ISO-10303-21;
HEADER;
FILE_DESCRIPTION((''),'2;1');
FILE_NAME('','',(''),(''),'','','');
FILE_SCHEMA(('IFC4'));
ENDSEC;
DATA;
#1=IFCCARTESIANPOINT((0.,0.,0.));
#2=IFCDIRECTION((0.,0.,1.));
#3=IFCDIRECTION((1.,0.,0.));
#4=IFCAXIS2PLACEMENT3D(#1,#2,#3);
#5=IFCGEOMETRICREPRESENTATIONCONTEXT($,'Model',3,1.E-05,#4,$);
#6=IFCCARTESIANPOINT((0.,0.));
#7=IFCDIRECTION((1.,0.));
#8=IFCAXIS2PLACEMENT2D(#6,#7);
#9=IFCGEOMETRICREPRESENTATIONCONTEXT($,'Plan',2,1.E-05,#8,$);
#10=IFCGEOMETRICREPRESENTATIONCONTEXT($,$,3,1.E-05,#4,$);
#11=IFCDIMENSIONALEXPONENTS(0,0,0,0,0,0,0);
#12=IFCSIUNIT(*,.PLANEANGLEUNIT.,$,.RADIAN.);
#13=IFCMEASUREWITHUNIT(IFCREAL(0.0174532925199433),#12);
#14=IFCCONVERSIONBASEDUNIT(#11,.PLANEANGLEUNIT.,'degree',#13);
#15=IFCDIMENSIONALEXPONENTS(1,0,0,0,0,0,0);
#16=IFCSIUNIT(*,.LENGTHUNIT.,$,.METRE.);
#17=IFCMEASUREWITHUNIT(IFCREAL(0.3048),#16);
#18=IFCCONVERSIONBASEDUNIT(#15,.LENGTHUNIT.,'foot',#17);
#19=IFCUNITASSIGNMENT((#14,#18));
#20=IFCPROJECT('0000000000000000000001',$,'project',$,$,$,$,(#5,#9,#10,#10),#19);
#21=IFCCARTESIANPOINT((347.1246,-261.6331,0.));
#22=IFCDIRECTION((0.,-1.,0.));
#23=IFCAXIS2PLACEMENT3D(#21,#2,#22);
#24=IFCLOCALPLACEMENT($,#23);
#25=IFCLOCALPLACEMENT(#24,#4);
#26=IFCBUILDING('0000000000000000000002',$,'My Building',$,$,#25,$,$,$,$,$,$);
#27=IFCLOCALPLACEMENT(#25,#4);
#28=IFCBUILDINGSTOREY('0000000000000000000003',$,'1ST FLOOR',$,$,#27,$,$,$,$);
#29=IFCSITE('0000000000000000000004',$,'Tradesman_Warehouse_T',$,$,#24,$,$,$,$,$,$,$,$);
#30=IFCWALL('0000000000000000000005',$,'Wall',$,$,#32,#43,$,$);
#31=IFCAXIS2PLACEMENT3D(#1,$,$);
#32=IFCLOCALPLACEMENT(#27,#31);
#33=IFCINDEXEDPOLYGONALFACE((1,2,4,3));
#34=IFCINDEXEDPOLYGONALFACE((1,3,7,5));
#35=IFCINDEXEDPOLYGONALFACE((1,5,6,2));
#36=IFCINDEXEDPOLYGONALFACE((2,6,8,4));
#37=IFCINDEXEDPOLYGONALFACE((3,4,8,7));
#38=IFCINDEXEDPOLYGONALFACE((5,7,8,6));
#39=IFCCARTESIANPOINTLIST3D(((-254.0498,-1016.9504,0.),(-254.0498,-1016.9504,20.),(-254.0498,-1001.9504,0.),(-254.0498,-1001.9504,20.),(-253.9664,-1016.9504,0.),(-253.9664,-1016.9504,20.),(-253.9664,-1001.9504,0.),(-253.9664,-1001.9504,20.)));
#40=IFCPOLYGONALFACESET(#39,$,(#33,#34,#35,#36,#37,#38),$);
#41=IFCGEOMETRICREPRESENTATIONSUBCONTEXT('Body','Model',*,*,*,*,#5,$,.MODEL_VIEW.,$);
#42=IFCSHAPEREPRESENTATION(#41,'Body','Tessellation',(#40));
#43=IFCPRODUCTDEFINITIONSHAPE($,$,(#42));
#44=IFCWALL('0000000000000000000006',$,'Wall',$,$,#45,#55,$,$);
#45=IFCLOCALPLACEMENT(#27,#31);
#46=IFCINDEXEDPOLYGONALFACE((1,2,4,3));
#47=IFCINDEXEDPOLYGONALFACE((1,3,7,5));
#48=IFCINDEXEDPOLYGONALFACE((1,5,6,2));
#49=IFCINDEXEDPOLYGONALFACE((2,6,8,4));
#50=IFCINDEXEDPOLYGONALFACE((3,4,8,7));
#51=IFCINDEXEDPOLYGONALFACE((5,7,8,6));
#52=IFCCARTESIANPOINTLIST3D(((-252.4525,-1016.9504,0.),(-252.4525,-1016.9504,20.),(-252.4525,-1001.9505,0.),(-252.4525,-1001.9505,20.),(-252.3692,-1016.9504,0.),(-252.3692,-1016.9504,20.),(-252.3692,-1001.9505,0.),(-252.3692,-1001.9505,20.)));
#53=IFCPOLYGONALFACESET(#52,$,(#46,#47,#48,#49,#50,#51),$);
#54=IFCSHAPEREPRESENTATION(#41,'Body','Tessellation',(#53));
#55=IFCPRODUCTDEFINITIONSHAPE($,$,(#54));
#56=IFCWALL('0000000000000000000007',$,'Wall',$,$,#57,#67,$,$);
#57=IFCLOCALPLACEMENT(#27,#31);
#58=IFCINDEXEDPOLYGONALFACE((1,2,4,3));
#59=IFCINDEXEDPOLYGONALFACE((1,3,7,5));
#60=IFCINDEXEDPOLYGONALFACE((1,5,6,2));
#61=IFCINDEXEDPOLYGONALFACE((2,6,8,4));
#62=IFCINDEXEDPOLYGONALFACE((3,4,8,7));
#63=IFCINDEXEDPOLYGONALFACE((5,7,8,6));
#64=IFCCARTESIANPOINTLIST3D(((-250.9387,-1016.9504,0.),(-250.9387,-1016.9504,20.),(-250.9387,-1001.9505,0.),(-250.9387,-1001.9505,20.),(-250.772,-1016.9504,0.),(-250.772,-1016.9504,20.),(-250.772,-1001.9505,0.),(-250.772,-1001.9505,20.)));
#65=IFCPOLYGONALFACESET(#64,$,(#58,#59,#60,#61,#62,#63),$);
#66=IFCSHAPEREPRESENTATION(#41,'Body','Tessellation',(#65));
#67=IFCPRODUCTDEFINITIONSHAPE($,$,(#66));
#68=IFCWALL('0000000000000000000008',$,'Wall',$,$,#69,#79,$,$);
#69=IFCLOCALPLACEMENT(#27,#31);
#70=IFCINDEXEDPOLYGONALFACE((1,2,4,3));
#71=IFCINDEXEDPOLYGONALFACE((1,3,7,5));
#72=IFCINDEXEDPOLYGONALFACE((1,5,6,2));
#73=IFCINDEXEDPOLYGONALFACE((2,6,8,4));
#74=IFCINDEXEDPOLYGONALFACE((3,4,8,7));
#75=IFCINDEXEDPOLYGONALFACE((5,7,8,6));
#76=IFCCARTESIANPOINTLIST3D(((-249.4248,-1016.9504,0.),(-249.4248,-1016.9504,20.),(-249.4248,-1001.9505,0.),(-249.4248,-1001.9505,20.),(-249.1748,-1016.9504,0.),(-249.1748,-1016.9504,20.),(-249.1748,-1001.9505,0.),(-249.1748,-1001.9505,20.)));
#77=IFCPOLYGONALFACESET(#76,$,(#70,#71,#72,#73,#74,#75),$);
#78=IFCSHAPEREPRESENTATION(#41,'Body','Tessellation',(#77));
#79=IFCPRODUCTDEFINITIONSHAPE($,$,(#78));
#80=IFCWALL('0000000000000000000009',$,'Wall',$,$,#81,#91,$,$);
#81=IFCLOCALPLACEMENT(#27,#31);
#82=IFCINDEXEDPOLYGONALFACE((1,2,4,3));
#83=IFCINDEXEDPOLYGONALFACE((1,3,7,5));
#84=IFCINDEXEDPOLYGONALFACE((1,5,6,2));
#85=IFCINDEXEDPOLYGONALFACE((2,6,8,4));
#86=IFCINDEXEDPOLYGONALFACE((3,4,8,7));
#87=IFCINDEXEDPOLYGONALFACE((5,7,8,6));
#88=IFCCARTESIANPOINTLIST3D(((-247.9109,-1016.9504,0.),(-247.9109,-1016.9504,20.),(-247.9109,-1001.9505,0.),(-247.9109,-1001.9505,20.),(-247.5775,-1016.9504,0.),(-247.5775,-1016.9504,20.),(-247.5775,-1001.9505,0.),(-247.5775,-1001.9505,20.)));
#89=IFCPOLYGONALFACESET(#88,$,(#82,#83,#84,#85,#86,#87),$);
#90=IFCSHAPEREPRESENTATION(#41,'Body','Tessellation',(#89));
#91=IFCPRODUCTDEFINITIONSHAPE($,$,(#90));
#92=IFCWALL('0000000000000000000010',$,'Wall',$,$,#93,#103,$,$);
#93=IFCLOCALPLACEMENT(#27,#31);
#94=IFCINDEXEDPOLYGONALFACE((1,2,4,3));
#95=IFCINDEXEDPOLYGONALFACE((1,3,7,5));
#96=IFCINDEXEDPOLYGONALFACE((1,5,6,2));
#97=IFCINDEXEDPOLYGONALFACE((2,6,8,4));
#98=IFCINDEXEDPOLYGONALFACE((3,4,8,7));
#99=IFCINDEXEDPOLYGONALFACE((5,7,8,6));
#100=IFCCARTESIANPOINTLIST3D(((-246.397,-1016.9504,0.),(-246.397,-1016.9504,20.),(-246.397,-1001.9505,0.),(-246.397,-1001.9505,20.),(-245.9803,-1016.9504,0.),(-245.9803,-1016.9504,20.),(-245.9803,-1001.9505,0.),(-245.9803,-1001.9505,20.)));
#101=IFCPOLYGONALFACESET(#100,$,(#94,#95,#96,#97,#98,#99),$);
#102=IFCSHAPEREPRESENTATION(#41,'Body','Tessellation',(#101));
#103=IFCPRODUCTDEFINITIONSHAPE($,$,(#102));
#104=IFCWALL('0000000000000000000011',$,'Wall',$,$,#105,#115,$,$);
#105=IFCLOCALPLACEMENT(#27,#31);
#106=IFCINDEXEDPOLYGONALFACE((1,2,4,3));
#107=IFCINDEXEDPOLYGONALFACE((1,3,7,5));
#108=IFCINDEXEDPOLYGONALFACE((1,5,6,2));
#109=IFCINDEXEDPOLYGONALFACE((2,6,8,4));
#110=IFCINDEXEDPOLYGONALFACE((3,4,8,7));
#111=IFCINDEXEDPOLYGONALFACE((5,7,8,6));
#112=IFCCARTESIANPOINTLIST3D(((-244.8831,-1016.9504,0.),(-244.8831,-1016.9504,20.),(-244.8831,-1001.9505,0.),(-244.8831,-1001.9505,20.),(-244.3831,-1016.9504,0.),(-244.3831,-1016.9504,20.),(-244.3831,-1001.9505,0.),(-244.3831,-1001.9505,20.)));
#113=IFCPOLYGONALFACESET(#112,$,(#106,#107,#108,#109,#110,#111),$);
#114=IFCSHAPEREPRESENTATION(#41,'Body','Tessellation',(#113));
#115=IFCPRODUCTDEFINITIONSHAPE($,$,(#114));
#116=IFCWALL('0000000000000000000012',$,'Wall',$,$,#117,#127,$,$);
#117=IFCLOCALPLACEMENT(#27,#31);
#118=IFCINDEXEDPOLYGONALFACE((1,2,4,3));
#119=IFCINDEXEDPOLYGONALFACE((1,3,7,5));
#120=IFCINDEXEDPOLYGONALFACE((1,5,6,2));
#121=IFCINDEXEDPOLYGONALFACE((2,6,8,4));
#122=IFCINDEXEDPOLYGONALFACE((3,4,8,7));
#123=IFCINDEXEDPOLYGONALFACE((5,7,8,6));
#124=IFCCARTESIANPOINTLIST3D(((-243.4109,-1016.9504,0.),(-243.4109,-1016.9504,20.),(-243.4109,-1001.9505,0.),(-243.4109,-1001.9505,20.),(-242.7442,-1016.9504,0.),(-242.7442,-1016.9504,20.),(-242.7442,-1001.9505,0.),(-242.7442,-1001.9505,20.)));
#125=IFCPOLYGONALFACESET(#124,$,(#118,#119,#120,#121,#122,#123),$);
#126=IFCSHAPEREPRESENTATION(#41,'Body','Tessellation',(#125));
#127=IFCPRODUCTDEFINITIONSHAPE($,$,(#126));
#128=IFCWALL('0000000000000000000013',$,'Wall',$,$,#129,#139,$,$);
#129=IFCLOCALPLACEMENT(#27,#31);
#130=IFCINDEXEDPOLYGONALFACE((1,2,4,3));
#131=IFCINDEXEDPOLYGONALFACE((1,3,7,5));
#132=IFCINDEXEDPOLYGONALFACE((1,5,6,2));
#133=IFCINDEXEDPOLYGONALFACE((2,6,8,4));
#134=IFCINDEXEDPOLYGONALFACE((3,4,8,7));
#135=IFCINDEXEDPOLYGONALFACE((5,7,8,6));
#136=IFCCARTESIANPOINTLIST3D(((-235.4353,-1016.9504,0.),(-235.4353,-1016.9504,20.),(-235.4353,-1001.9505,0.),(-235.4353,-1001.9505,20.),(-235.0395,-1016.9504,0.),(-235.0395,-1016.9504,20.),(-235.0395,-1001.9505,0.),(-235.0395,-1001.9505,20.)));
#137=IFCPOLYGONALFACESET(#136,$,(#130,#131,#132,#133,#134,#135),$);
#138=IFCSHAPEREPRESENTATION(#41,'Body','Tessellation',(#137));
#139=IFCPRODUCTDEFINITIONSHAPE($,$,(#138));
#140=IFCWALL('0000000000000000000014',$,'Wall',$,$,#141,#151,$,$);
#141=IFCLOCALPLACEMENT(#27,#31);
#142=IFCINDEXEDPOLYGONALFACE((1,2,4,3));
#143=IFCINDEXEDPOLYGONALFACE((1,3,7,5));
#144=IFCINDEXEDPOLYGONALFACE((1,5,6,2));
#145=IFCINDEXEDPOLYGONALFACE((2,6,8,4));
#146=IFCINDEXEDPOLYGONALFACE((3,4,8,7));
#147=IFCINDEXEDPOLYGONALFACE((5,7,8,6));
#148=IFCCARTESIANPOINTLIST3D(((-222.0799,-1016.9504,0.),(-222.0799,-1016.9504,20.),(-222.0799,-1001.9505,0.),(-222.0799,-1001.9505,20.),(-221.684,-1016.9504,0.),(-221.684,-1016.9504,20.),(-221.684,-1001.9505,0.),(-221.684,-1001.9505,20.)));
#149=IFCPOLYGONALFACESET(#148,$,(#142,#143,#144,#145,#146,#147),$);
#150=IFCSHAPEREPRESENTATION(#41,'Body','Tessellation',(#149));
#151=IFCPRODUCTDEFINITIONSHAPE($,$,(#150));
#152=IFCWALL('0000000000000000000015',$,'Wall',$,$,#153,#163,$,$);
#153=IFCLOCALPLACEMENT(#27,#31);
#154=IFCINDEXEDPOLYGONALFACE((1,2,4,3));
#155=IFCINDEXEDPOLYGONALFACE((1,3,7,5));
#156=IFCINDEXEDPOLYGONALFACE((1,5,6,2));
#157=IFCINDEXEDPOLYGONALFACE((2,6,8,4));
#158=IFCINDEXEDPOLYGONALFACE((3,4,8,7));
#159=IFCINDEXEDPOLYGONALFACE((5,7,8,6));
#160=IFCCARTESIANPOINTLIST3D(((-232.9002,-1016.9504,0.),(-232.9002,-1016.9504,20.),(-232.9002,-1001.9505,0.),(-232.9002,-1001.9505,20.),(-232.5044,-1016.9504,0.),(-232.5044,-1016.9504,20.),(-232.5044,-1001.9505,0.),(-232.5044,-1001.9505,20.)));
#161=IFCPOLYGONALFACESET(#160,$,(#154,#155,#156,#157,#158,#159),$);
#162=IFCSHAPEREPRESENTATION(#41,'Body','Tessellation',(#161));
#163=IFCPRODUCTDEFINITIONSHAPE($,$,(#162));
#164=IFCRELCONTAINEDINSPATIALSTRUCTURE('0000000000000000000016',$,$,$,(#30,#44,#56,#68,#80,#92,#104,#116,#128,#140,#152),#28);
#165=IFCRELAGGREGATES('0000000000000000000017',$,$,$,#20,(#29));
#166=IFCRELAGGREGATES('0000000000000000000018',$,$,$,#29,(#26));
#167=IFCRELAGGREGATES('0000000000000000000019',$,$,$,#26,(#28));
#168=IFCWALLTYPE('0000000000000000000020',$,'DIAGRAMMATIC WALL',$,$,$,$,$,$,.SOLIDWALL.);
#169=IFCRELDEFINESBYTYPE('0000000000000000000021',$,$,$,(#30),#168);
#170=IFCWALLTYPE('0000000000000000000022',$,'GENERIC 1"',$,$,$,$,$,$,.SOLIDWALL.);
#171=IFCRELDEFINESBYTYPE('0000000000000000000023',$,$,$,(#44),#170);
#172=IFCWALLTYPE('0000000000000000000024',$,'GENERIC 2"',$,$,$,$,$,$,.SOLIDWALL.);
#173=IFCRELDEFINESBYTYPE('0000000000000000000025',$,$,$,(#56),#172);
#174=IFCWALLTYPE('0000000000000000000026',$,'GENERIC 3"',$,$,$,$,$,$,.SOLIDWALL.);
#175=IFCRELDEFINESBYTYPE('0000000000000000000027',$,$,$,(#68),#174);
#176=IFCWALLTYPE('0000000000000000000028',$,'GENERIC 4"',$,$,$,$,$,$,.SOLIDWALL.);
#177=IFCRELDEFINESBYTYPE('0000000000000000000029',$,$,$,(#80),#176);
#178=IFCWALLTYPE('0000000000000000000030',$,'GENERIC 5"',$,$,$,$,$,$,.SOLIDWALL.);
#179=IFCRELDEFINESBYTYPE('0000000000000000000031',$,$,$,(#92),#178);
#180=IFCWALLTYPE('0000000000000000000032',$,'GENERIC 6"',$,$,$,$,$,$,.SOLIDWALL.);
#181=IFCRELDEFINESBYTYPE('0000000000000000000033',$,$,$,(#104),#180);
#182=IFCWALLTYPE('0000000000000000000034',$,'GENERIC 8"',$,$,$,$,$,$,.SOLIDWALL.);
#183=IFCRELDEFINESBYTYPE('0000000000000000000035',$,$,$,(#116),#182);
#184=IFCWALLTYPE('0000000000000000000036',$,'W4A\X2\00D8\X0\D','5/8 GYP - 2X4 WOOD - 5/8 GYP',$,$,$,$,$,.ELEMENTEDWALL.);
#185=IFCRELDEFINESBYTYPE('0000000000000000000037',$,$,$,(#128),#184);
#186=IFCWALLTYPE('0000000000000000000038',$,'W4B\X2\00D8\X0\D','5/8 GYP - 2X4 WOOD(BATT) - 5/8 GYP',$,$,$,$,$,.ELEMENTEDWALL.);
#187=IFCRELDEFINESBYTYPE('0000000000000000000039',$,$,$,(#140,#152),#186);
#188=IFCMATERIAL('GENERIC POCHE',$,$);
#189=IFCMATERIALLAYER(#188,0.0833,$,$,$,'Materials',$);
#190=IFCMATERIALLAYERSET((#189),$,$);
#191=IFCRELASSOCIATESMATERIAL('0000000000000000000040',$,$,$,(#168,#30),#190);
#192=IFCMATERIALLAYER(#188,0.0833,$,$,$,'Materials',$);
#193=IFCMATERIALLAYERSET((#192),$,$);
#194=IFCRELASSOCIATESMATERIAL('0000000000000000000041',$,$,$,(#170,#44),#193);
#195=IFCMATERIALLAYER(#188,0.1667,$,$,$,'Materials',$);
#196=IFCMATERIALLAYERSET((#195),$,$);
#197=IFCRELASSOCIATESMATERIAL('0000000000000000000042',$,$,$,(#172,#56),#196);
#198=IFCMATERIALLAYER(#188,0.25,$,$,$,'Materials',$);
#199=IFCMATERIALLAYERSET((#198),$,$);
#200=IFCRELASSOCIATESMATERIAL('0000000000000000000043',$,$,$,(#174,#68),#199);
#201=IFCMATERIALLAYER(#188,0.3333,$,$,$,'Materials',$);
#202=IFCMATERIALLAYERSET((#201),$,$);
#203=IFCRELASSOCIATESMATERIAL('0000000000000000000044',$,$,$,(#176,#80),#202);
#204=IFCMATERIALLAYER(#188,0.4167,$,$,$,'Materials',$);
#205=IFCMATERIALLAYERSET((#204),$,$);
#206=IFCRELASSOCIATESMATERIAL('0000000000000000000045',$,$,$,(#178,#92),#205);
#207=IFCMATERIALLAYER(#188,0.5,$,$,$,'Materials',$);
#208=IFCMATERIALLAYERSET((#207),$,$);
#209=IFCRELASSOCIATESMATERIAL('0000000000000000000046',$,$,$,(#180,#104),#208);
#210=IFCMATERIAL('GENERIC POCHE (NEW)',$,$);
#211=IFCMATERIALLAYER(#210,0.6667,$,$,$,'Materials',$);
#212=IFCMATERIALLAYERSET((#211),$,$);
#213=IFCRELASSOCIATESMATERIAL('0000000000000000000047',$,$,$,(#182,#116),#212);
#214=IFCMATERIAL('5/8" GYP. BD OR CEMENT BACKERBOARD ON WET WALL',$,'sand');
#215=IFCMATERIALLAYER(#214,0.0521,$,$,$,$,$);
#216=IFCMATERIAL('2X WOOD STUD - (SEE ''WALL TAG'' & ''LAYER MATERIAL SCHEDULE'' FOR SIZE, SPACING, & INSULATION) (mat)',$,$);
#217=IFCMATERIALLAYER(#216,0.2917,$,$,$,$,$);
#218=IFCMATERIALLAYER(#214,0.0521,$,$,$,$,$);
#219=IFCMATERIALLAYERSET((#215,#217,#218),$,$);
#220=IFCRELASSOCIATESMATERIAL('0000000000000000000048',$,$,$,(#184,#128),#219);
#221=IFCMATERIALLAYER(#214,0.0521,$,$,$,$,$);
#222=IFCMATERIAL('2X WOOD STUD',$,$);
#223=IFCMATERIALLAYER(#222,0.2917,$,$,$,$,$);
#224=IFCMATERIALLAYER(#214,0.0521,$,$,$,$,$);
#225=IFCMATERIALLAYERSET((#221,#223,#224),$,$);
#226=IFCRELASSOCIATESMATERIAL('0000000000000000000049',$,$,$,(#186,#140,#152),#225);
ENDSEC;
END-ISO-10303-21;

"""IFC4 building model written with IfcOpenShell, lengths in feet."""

from ifc_helpers import new_model, entity, si_unit, converted_unit, frame, origin_with_axes, origin_2d_with_axis, place, context, subcontext, project, spatial, indexed_curve, outline, extrude, material, layer, layer_set, layer_usage, type_object, element, save


model = new_model("IFC4")

# Units and contexts
model_context = context("Model", 3, precision=1e-05, world=origin_with_axes())
plan_context = context("Plan", 2, precision=1e-05, world=origin_2d_with_axis())
context_of_model = context(None, 3, precision=1e-05, world=origin_with_axes())
body_context = subcontext(model_context, "Body", "Model", "MODEL_VIEW")
ifc_project = project(units=[converted_unit("PLANEANGLEUNIT", "degree", entity("IfcReal", 0.0174532925199433), si_unit("PLANEANGLEUNIT", "RADIAN"), dimensions=[0, 0, 0, 0, 0, 0, 0]), converted_unit("LENGTHUNIT", "foot", entity("IfcReal", 0.3048), si_unit("LENGTHUNIT", "METRE"), dimensions=[1, 0, 0, 0, 0, 0, 0])], contexts=[model_context, plan_context, context_of_model, context_of_model])

# Site, building, storey
site_placement = place(None, frame((347.1246, -261.6331, 0.0), z_axis=(0.0, 0.0, 1.0), x_axis=(0.0, -1.0, 0.0)))
site = spatial("IfcSite", under=ifc_project, at=site_placement, Name="Tradesman_Warehouse_T")
building_placement = place(site_placement, frame((0.0, 0.0, 0.0), z_axis=(0.0, 0.0, 1.0), x_axis=(1.0, 0.0, 0.0)))
building = spatial("IfcBuilding", under=site, at=building_placement, Name="My Building")
storey_placement = place(building_placement, frame((0.0, 0.0, 0.0), z_axis=(0.0, 0.0, 1.0), x_axis=(1.0, 0.0, 0.0)))
storey = spatial("IfcBuildingStorey", under=building, at=storey_placement, Name="1ST FLOOR")

# Walls
ifc_material_1 = material(Name="GENERIC POCHE")
ifc_layer_1 = layer(ifc_material_1, 0.0833, Category="Materials")
ifc_layer_set_1 = layer_set([ifc_layer_1])
ifc_layer_usage_1 = layer_usage(ifc_layer_set_1, "AXIS2", "POSITIVE", 0.0)
wall_type_1 = type_object("IfcWallType", Name="DIAGRAMMATIC WALL", PredefinedType="SOLIDWALL", material=ifc_layer_set_1)
wall_1_placement = place(storey_placement, frame((-253.9664, -1016.9504, 0.0), z_axis=(0.0, 0.0, 1.0), x_axis=(0.0, 1.0, 0.0)))
element("IfcWall", 1, at=wall_1_placement, inside=storey, type_object=wall_type_1, material=ifc_layer_usage_1, Name="Wall", context=body_context, shape_type="SweptSolid", body=[
    extrude(outline(indexed_curve([(0.0, 0.0), (0.0, 0.0833), (15.0, 0.0833), (15.0, 0.0), (0.0, 0.0)], self_intersect=False)), origin_with_axes(), (0.0, 0.0, 1.0), 20.0),
])
ifc_layer_2 = layer(ifc_material_1, 0.0833, Category="Materials")
ifc_layer_set_2 = layer_set([ifc_layer_2])
ifc_layer_usage_2 = layer_usage(ifc_layer_set_2, "AXIS2", "POSITIVE", 0.0)
wall_type_2 = type_object("IfcWallType", Name="GENERIC 1\"", PredefinedType="SOLIDWALL", material=ifc_layer_set_2)
wall_2_placement = place(storey_placement, frame((-252.3692, -1016.9504, 0.0), z_axis=(0.0, 0.0, 1.0), x_axis=(0.0, 1.0, 0.0)))
element("IfcWall", 2, at=wall_2_placement, inside=storey, type_object=wall_type_2, material=ifc_layer_usage_2, Name="Wall", context=body_context, shape_type="SweptSolid", body=[
    extrude(outline(indexed_curve([(0.0, 0.0), (0.0, 0.0833), (15.0, 0.0833), (15.0, 0.0), (0.0, 0.0)], self_intersect=False)), origin_with_axes(), (0.0, 0.0, 1.0), 20.0),
])
ifc_layer_3 = layer(ifc_material_1, 0.1667, Category="Materials")
ifc_layer_set_3 = layer_set([ifc_layer_3])
ifc_layer_usage_3 = layer_usage(ifc_layer_set_3, "AXIS2", "POSITIVE", 0.0)
wall_type_3 = type_object("IfcWallType", Name="GENERIC 2\"", PredefinedType="SOLIDWALL", material=ifc_layer_set_3)
wall_3_placement = place(storey_placement, frame((-250.772, -1016.9504, 0.0), z_axis=(0.0, 0.0, 1.0), x_axis=(0.0, 1.0, 0.0)))
element("IfcWall", 3, at=wall_3_placement, inside=storey, type_object=wall_type_3, material=ifc_layer_usage_3, Name="Wall", context=body_context, shape_type="SweptSolid", body=[
    extrude(outline(indexed_curve([(0.0, 0.0), (0.0, 0.1667), (14.9999, 0.1667), (14.9999, 0.0), (0.0, 0.0)], self_intersect=False)), origin_with_axes(), (0.0, 0.0, 1.0), 20.0),
])
ifc_layer_4 = layer(ifc_material_1, 0.25, Category="Materials")
ifc_layer_set_4 = layer_set([ifc_layer_4])
ifc_layer_usage_4 = layer_usage(ifc_layer_set_4, "AXIS2", "POSITIVE", 0.0)
wall_type_4 = type_object("IfcWallType", Name="GENERIC 3\"", PredefinedType="SOLIDWALL", material=ifc_layer_set_4)
wall_4_placement = place(storey_placement, frame((-249.1748, -1016.9504, 0.0), z_axis=(0.0, 0.0, 1.0), x_axis=(0.0, 1.0, 0.0)))
element("IfcWall", 4, at=wall_4_placement, inside=storey, type_object=wall_type_4, material=ifc_layer_usage_4, Name="Wall", context=body_context, shape_type="SweptSolid", body=[
    extrude(outline(indexed_curve([(0.0, 0.0), (0.0, 0.25), (14.9999, 0.25), (14.9999, 0.0), (0.0, 0.0)], self_intersect=False)), origin_with_axes(), (0.0, 0.0, 1.0), 20.0),
])
ifc_layer_5 = layer(ifc_material_1, 0.3333, Category="Materials")
ifc_layer_set_5 = layer_set([ifc_layer_5])
ifc_layer_usage_5 = layer_usage(ifc_layer_set_5, "AXIS2", "POSITIVE", 0.0)
wall_type_5 = type_object("IfcWallType", Name="GENERIC 4\"", PredefinedType="SOLIDWALL", material=ifc_layer_set_5)
wall_5_placement = place(storey_placement, frame((-247.5775, -1016.9504, 0.0), z_axis=(0.0, 0.0, 1.0), x_axis=(0.0, 1.0, 0.0)))
element("IfcWall", 5, at=wall_5_placement, inside=storey, type_object=wall_type_5, material=ifc_layer_usage_5, Name="Wall", context=body_context, shape_type="SweptSolid", body=[
    extrude(outline(indexed_curve([(0.0, 0.0), (0.0, 0.3333), (14.9999, 0.3333), (14.9999, 0.0), (0.0, 0.0)], self_intersect=False)), origin_with_axes(), (0.0, 0.0, 1.0), 20.0),
])
ifc_layer_6 = layer(ifc_material_1, 0.4167, Category="Materials")
ifc_layer_set_6 = layer_set([ifc_layer_6])
ifc_layer_usage_6 = layer_usage(ifc_layer_set_6, "AXIS2", "POSITIVE", 0.0)
wall_type_6 = type_object("IfcWallType", Name="GENERIC 5\"", PredefinedType="SOLIDWALL", material=ifc_layer_set_6)
wall_6_placement = place(storey_placement, frame((-245.9803, -1016.9504, 0.0), z_axis=(0.0, 0.0, 1.0), x_axis=(0.0, 1.0, 0.0)))
element("IfcWall", 6, at=wall_6_placement, inside=storey, type_object=wall_type_6, material=ifc_layer_usage_6, Name="Wall", context=body_context, shape_type="SweptSolid", body=[
    extrude(outline(indexed_curve([(0.0, 0.0), (0.0, 0.4167), (14.9999, 0.4167), (14.9999, 0.0), (0.0, 0.0)], self_intersect=False)), origin_with_axes(), (0.0, 0.0, 1.0), 20.0),
])
ifc_layer_7 = layer(ifc_material_1, 0.5, Category="Materials")
ifc_layer_set_7 = layer_set([ifc_layer_7])
ifc_layer_usage_7 = layer_usage(ifc_layer_set_7, "AXIS2", "POSITIVE", 0.0)
wall_type_7 = type_object("IfcWallType", Name="GENERIC 6\"", PredefinedType="SOLIDWALL", material=ifc_layer_set_7)
wall_7_placement = place(storey_placement, frame((-244.3831, -1016.9504, 0.0), z_axis=(0.0, 0.0, 1.0), x_axis=(0.0, 1.0, 0.0)))
element("IfcWall", 7, at=wall_7_placement, inside=storey, type_object=wall_type_7, material=ifc_layer_usage_7, Name="Wall", context=body_context, shape_type="SweptSolid", body=[
    extrude(outline(indexed_curve([(0.0, 0.0), (0.0, 0.5), (14.9999, 0.5), (14.9999, 0.0), (0.0, 0.0)], self_intersect=False)), origin_with_axes(), (0.0, 0.0, 1.0), 20.0),
])
ifc_material_2 = material(Name="GENERIC POCHE (NEW)")
ifc_layer_8 = layer(ifc_material_2, 0.6667, Category="Materials")
ifc_layer_set_8 = layer_set([ifc_layer_8])
ifc_layer_usage_8 = layer_usage(ifc_layer_set_8, "AXIS2", "POSITIVE", 0.0)
wall_type_8 = type_object("IfcWallType", Name="GENERIC 8\"", PredefinedType="SOLIDWALL", material=ifc_layer_set_8)
wall_8_placement = place(storey_placement, frame((-242.7442, -1016.9504, 0.0), z_axis=(0.0, 0.0, 1.0), x_axis=(0.0, 1.0, 0.0)))
element("IfcWall", 8, at=wall_8_placement, inside=storey, type_object=wall_type_8, material=ifc_layer_usage_8, Name="Wall", context=body_context, shape_type="SweptSolid", body=[
    extrude(outline(indexed_curve([(0.0, 0.0), (0.0, 0.6667), (14.9999, 0.6667), (14.9999, 0.0), (0.0, 0.0)], self_intersect=False)), origin_with_axes(), (0.0, 0.0, 1.0), 20.0),
])
ifc_material_3 = material(Name="5/8\" GYP. BD OR CEMENT BACKERBOARD ON WET WALL", Category="sand")
ifc_layer_9 = layer(ifc_material_3, 0.0521)
ifc_material_4 = material(Name="2X WOOD STUD - (SEE 'WALL TAG' & 'LAYER MATERIAL SCHEDULE' FOR SIZE, SPACING, & INSULATION) (mat)")
ifc_layer_10 = layer(ifc_material_4, 0.2917)
ifc_layer_11 = layer(ifc_material_3, 0.0521)
ifc_layer_set_9 = layer_set([ifc_layer_9, ifc_layer_10, ifc_layer_11])
ifc_layer_usage_9 = layer_usage(ifc_layer_set_9, "AXIS2", "POSITIVE", 0.0)
wall_type_9 = type_object("IfcWallType", Name="W4AØD", Description="5/8 GYP - 2X4 WOOD - 5/8 GYP", PredefinedType="ELEMENTEDWALL", material=ifc_layer_set_9)
wall_9_placement = place(storey_placement, frame((-235.0395, -1016.9504, 0.0), z_axis=(0.0, 0.0, 1.0), x_axis=(0.0, 1.0, 0.0)))
element("IfcWall", 9, at=wall_9_placement, inside=storey, type_object=wall_type_9, material=ifc_layer_usage_9, Name="Wall", context=body_context, shape_type="SweptSolid", body=[
    extrude(outline(indexed_curve([(0.0, 0.0), (0.0, 0.3958), (14.9999, 0.3958), (14.9999, 0.0), (0.0, 0.0)], self_intersect=False)), origin_with_axes(), (0.0, 0.0, 1.0), 20.0),
])
ifc_layer_12 = layer(ifc_material_3, 0.0521)
ifc_material_5 = material(Name="2X WOOD STUD")
ifc_layer_13 = layer(ifc_material_5, 0.2917)
ifc_layer_14 = layer(ifc_material_3, 0.0521)
ifc_layer_set_10 = layer_set([ifc_layer_12, ifc_layer_13, ifc_layer_14])
ifc_layer_usage_10 = layer_usage(ifc_layer_set_10, "AXIS2", "POSITIVE", 0.0)
wall_type_10 = type_object("IfcWallType", Name="W4BØD", Description="5/8 GYP - 2X4 WOOD(BATT) - 5/8 GYP", PredefinedType="ELEMENTEDWALL", material=ifc_layer_set_10)
wall_10_placement = place(storey_placement, frame((-221.684, -1016.9504, 0.0), z_axis=(0.0, 0.0, 1.0), x_axis=(0.0, 1.0, 0.0)))
element("IfcWall", 10, at=wall_10_placement, inside=storey, type_object=wall_type_10, material=ifc_layer_usage_10, Name="Wall", context=body_context, shape_type="SweptSolid", body=[
    extrude(outline(indexed_curve([(0.0, 0.0), (0.0, 0.3958), (14.9999, 0.3958), (14.9999, 0.0), (0.0, 0.0)], self_intersect=False)), origin_with_axes(), (0.0, 0.0, 1.0), 20.0),
])
ifc_layer_usage_11 = layer_usage(ifc_layer_set_10, "AXIS2", "POSITIVE", 0.0)
wall_11_placement = place(storey_placement, frame((-232.5044, -1016.9504, 0.0), z_axis=(0.0, 0.0, 1.0), x_axis=(0.0, 1.0, 0.0)))
element("IfcWall", 11, at=wall_11_placement, inside=storey, type_object=wall_type_10, material=ifc_layer_usage_11, Name="Wall", context=body_context, shape_type="SweptSolid", body=[
    extrude(outline(indexed_curve([(0.0, 0.0), (0.0, 0.3958), (14.9999, 0.3958), (14.9999, 0.0), (0.0, 0.0)], self_intersect=False)), origin_with_axes(), (0.0, 0.0, 1.0), 20.0),
])

save(model, "model.ifc")
